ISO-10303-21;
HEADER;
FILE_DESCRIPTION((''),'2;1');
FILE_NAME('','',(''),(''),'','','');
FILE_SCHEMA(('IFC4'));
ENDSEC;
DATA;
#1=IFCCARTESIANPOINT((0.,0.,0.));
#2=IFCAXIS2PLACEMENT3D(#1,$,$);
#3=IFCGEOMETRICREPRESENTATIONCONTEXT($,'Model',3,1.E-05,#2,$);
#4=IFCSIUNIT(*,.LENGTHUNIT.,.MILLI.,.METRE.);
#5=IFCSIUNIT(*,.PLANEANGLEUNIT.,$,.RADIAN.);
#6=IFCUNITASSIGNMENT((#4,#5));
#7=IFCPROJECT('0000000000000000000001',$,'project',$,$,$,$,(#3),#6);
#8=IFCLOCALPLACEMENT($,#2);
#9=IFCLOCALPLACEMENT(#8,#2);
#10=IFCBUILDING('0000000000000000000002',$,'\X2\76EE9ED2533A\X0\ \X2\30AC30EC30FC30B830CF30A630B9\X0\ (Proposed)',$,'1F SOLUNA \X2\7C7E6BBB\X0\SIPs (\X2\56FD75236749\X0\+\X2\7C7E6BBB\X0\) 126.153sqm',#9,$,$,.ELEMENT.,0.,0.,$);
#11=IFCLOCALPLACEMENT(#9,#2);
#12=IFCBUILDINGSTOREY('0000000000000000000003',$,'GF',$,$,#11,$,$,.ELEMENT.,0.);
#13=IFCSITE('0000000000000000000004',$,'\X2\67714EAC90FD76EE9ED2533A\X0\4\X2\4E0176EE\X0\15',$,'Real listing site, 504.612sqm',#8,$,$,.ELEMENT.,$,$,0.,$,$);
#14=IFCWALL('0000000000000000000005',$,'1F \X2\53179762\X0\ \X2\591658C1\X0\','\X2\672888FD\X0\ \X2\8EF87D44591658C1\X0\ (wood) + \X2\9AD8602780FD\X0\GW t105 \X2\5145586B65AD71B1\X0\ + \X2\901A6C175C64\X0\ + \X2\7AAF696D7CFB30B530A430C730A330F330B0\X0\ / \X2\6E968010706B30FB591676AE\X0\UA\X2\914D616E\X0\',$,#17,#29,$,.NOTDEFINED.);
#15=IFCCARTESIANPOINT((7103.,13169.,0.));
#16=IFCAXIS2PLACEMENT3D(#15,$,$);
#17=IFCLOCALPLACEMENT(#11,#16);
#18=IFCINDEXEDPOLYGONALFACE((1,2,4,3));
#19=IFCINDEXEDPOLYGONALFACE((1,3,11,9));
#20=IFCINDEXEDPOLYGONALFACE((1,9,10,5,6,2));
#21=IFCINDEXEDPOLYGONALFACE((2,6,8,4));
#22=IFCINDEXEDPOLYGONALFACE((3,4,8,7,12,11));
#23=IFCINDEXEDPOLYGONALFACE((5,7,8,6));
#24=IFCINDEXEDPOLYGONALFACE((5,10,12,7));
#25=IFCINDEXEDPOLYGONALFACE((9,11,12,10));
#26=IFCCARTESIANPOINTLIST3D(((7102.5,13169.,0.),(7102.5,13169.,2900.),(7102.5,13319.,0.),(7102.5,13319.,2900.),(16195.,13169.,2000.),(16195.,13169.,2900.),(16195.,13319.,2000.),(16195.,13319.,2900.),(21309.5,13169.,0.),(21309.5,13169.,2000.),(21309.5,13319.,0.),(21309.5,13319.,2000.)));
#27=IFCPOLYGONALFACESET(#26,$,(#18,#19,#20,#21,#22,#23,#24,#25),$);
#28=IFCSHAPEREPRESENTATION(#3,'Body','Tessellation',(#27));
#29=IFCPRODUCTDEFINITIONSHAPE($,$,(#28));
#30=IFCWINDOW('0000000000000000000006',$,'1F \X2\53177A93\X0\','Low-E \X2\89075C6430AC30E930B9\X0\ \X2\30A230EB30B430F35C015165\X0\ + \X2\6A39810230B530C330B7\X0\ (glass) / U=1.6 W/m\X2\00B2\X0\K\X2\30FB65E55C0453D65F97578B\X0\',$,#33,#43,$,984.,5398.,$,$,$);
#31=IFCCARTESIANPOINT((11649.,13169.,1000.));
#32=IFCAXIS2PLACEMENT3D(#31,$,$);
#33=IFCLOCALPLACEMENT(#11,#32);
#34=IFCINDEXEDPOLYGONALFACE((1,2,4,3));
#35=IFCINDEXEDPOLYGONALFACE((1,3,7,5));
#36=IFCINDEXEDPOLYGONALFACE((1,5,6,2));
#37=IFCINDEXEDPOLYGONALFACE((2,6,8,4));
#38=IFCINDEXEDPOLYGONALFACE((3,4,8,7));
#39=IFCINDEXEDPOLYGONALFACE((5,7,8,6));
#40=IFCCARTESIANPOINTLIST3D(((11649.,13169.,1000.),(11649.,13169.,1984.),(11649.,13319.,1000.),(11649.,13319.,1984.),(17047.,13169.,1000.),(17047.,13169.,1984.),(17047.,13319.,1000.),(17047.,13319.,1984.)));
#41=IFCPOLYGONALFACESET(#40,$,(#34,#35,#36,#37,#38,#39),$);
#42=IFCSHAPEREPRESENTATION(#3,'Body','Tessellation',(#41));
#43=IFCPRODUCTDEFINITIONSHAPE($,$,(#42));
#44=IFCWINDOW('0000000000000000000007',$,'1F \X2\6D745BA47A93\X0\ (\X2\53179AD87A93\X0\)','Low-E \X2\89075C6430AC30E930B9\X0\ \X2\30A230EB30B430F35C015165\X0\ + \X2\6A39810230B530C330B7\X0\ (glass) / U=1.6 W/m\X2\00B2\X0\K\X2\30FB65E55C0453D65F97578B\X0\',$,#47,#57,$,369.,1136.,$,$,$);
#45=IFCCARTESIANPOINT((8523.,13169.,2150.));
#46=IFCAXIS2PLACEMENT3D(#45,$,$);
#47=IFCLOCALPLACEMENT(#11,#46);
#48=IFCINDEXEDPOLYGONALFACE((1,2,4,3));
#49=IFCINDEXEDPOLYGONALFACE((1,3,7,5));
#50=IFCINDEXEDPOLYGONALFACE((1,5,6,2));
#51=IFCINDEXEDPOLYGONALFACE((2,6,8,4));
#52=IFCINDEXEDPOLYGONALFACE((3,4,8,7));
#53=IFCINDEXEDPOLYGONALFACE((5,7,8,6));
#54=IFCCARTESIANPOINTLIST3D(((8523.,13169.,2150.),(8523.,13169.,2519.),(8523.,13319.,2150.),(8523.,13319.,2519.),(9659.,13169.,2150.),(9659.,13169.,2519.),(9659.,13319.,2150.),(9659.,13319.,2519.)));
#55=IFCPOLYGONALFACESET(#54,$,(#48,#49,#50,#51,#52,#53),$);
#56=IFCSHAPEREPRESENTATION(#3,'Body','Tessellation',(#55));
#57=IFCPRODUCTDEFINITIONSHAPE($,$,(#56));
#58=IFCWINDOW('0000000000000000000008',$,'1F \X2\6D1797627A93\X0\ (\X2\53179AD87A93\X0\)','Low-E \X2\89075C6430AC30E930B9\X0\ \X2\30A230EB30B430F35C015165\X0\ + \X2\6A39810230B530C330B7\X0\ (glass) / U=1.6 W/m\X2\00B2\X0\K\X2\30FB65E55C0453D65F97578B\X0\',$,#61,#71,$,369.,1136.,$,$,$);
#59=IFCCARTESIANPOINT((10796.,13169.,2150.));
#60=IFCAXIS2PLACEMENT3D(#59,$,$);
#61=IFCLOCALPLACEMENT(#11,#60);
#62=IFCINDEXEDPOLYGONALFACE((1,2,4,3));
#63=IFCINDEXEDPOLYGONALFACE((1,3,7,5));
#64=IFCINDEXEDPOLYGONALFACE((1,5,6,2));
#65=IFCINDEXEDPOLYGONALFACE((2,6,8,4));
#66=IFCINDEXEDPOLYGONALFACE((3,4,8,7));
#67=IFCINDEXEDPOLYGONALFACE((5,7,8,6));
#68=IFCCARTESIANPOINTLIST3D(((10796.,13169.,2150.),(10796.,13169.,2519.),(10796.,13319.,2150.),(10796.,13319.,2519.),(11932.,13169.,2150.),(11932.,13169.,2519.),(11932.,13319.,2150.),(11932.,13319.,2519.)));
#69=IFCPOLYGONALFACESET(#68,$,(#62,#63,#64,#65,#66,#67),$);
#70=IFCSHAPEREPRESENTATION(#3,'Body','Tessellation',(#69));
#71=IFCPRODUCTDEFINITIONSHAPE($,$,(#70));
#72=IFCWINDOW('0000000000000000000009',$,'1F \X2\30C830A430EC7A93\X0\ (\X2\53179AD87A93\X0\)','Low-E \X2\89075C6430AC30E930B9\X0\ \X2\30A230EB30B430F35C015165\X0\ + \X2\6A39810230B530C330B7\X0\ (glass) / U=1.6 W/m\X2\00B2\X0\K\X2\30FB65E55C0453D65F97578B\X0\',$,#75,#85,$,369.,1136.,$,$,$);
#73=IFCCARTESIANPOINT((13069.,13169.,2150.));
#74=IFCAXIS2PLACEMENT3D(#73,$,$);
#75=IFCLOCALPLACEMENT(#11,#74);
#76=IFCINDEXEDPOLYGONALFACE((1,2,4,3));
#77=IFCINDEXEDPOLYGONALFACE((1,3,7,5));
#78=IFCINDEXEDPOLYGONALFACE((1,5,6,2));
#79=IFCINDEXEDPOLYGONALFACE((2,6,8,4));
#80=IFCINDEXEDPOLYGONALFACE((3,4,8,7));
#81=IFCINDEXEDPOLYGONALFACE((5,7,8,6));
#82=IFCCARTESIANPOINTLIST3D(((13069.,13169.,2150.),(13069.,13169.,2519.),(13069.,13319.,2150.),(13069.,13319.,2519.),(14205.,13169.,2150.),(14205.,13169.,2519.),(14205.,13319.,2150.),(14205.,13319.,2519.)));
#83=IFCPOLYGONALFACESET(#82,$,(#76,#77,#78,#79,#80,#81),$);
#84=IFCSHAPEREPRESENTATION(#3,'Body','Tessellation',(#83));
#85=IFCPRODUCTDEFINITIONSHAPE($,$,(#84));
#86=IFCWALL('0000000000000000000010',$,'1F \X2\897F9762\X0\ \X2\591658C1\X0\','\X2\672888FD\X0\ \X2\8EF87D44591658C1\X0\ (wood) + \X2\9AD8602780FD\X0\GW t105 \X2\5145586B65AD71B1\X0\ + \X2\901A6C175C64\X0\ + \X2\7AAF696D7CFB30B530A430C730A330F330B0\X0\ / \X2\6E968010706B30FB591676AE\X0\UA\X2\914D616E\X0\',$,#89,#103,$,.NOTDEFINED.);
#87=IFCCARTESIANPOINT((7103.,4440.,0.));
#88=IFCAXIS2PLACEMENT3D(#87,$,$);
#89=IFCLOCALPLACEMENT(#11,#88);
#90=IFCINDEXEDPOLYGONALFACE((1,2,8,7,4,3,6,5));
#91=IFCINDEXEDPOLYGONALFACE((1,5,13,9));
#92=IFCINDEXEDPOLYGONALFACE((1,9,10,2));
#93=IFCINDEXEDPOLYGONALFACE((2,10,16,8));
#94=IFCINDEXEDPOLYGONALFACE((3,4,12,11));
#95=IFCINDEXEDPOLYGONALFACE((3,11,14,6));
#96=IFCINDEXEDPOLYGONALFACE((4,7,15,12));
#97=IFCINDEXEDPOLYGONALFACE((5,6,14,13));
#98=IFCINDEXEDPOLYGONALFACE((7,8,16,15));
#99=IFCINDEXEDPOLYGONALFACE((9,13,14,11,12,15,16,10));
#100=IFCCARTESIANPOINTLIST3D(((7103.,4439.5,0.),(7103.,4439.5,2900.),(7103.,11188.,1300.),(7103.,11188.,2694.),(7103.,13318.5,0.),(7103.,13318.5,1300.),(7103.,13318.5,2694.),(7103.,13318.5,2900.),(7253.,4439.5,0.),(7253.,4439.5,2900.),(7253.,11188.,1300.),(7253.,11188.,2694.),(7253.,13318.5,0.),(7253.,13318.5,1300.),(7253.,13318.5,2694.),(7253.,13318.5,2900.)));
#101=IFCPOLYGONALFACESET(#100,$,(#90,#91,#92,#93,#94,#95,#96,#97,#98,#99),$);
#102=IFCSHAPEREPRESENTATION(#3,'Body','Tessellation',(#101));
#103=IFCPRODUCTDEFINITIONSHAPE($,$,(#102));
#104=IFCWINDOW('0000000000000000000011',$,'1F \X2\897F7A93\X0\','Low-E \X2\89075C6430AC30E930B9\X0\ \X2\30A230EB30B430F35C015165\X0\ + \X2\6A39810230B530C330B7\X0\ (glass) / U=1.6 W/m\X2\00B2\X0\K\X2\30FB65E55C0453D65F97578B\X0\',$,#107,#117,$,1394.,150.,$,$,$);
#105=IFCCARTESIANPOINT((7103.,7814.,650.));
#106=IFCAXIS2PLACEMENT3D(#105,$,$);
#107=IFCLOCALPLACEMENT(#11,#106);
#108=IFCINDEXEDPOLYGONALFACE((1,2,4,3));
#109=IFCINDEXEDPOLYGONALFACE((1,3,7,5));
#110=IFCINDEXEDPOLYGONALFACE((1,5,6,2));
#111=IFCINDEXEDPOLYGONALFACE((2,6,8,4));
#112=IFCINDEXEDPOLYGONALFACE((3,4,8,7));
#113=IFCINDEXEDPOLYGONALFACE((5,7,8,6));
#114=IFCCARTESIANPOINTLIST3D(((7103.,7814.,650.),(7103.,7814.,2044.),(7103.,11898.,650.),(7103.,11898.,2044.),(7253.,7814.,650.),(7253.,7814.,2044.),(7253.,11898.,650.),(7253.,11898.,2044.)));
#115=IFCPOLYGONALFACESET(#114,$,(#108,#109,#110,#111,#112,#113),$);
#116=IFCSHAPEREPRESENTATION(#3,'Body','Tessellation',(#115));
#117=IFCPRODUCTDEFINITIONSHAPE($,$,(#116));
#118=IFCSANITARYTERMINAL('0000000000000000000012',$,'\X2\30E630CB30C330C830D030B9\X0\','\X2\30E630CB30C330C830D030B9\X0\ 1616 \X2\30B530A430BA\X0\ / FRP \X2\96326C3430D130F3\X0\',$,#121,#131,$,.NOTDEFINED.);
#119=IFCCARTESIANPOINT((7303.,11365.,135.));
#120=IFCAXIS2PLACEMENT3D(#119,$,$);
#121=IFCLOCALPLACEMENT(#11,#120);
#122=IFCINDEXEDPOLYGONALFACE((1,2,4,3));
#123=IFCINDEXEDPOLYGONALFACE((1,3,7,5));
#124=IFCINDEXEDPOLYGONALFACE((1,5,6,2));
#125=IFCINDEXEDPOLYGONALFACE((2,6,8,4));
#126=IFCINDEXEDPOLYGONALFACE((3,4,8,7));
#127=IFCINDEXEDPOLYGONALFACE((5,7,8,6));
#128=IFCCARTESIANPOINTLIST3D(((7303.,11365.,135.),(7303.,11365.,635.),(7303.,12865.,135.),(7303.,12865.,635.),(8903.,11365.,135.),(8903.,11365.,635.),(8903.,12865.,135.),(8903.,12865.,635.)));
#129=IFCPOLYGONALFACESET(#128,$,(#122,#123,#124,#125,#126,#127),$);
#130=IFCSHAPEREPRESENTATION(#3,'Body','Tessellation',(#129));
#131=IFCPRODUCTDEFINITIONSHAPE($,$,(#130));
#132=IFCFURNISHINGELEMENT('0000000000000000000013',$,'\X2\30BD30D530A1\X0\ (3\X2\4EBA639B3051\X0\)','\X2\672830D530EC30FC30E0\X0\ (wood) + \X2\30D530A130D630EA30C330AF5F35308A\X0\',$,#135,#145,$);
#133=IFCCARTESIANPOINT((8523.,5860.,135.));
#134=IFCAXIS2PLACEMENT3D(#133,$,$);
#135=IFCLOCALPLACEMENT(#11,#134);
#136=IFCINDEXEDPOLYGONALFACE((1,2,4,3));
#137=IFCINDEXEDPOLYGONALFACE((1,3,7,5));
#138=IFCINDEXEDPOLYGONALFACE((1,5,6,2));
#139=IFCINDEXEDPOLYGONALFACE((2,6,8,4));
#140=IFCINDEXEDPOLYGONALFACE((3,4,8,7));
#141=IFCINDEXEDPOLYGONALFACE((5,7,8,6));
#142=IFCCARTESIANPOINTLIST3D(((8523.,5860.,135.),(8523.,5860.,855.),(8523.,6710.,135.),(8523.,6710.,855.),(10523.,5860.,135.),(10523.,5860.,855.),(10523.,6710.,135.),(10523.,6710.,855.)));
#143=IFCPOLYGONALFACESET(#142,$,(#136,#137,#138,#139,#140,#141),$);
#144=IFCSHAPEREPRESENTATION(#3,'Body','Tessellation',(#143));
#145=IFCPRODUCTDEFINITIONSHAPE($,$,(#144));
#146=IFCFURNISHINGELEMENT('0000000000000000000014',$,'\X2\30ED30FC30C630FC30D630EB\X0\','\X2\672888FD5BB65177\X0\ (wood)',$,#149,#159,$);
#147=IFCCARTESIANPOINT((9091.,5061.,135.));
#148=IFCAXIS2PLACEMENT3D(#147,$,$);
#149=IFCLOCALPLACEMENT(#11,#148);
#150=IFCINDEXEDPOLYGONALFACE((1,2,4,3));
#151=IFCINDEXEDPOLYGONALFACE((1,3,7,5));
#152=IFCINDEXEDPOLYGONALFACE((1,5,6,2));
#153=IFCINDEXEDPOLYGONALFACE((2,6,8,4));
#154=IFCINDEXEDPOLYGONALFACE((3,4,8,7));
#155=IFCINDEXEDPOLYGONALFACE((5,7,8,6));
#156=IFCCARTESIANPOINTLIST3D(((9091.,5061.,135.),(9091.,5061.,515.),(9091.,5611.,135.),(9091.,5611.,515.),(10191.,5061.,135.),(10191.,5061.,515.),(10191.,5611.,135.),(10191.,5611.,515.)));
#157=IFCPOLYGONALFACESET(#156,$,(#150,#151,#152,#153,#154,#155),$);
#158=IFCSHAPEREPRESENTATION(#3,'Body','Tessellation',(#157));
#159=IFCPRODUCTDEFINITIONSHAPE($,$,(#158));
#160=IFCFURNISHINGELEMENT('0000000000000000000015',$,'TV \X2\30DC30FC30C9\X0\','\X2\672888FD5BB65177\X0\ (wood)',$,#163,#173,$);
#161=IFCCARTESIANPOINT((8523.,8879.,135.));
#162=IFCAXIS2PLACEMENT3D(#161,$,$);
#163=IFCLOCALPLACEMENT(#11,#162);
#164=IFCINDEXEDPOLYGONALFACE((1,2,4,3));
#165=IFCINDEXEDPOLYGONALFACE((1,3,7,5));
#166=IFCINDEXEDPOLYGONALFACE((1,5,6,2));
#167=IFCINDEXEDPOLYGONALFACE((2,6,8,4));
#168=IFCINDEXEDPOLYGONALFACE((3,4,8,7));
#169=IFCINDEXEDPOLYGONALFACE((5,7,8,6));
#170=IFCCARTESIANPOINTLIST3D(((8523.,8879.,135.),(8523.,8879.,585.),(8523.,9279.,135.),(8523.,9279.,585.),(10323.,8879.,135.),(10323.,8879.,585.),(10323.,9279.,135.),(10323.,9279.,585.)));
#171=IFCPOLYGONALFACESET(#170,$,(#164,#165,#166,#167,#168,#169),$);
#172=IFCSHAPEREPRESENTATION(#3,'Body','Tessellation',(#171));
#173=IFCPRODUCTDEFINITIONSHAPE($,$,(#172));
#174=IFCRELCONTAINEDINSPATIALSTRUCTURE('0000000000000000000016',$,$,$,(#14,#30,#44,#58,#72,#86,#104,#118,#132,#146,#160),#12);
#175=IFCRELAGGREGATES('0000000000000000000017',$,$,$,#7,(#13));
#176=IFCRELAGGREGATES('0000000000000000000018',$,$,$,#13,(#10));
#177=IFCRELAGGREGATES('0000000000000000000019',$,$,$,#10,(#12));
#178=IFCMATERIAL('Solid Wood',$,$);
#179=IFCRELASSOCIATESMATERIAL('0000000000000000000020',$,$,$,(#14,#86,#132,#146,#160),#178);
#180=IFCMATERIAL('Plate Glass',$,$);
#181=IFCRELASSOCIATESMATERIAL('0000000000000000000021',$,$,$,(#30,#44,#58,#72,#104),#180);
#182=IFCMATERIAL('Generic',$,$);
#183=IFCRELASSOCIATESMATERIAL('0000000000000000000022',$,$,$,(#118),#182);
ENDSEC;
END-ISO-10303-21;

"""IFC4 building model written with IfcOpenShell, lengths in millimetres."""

from ifc_helpers import new_model, si_unit, frame, frame_2d, origin, place, context, project, spatial, rectangle, extrude, material, element, fill, save


model = new_model("IFC4")

# Units and contexts
model_context = context("Model", 3, precision=1e-05, world=origin())
ifc_project = project(units=[si_unit("LENGTHUNIT", "METRE", prefix="MILLI"), si_unit("PLANEANGLEUNIT", "RADIAN")], contexts=[model_context])

# Site, building, storey
site_placement = place(None, origin())
site = spatial("IfcSite", under=ifc_project, at=site_placement, Name="東京都目黒区4丁目15", ObjectType="Real listing site, 504.612sqm", CompositionType="ELEMENT", RefElevation=0.0)
building_placement = place(site_placement, origin())
building = spatial("IfcBuilding", under=site, at=building_placement, Name="目黒区 ガレージハウス (Proposed)", ObjectType="1F SOLUNA 籾殻SIPs (国産杉+籾殻) 126.153sqm", CompositionType="ELEMENT", ElevationOfRefHeight=0.0, ElevationOfTerrain=0.0)
storey_placement = place(building_placement, origin())
storey = spatial("IfcBuildingStorey", under=building, at=storey_placement, Name="GF", CompositionType="ELEMENT", Elevation=0.0)

# Shared definitions
ifc_material_1 = material(Name="Solid Wood")

# Shared definitions
ifc_material_2 = material(Name="Plate Glass")

# Wall, openings, windows
wall_1_placement = place(storey_placement, frame((7103.0, 13169.0, 0.0)))
wall_1 = element("IfcWall", 1, at=wall_1_placement, inside=storey, material=ifc_material_1, Name="1F 北面 外壁", Description="木製 軸組外壁 (wood) + 高性能GW t105 充填断熱 + 通気層 + 窯業系サイディング / 準耐火・外皮UA配慮", PredefinedType="NOTDEFINED", context=model_context, shape_type="SweptSolid", body=[
    extrude(rectangle(XDim=14207.0, YDim=150.0, at=frame_2d((7103.0, 75.0))), frame((7103.0, 13169.0, 0.0)), (0.0, 0.0, 1.0), 2900.0),
])
opening_1_placement = place(storey_placement, frame((11649.0, 13169.0, 1000.0)))
opening_1 = element("IfcOpeningElement", 2, at=opening_1_placement, cuts=wall_1, PredefinedType="NOTDEFINED", context=model_context, shape_type="SweptSolid", body=[
    extrude(rectangle(XDim=5398.0, YDim=150.0, at=frame_2d((2699.0, 75.0))), frame((11649.0, 13169.0, 1000.0)), (0.0, 0.0, 1.0), 984.0),
])
opening_2_placement = place(storey_placement, frame((8523.0, 13169.0, 2150.0)))
opening_2 = element("IfcOpeningElement", 3, at=opening_2_placement, cuts=wall_1, PredefinedType="NOTDEFINED", context=model_context, shape_type="SweptSolid", body=[
    extrude(rectangle(XDim=1136.0, YDim=150.0, at=frame_2d((568.0, 75.0))), frame((8523.0, 13169.0, 2150.0)), (0.0, 0.0, 1.0), 369.0),
])
opening_3_placement = place(storey_placement, frame((10796.0, 13169.0, 2150.0)))
opening_3 = element("IfcOpeningElement", 4, at=opening_3_placement, cuts=wall_1, PredefinedType="NOTDEFINED", context=model_context, shape_type="SweptSolid", body=[
    extrude(rectangle(XDim=1136.0, YDim=150.0, at=frame_2d((568.0, 75.0))), frame((10796.0, 13169.0, 2150.0)), (0.0, 0.0, 1.0), 369.0),
])
opening_4_placement = place(storey_placement, frame((13069.0, 13169.0, 2150.0)))
opening_4 = element("IfcOpeningElement", 5, at=opening_4_placement, cuts=wall_1, PredefinedType="NOTDEFINED", context=model_context, shape_type="SweptSolid", body=[
    extrude(rectangle(XDim=1136.0, YDim=150.0, at=frame_2d((568.0, 75.0))), frame((13069.0, 13169.0, 2150.0)), (0.0, 0.0, 1.0), 369.0),
])
window_1_placement = place(storey_placement, frame((11649.0, 13169.0, 1000.0)))
window_1 = element("IfcWindow", 6, at=window_1_placement, inside=storey, material=ifc_material_2, Name="1F 北窓", Description="Low-E 複層ガラス アルゴン封入 + 樹脂サッシ (glass) / U=1.6 W/m²K・日射取得型", OverallHeight=984.0, OverallWidth=5398.0, context=model_context, shape_type="SweptSolid", body=[
    extrude(rectangle(XDim=5398.0, YDim=150.0, at=frame_2d((2699.0, 75.0))), frame((11649.0, 13169.0, 1000.0)), (0.0, 0.0, 1.0), 984.0),
])
fill(opening_1, window_1)
window_2_placement = place(storey_placement, frame((8523.0, 13169.0, 2150.0)))
window_2 = element("IfcWindow", 7, at=window_2_placement, inside=storey, material=ifc_material_2, Name="1F 浴室窓 (北高窓)", Description="Low-E 複層ガラス アルゴン封入 + 樹脂サッシ (glass) / U=1.6 W/m²K・日射取得型", OverallHeight=369.0, OverallWidth=1136.0, context=model_context, shape_type="SweptSolid", body=[
    extrude(rectangle(XDim=1136.0, YDim=150.0, at=frame_2d((568.0, 75.0))), frame((8523.0, 13169.0, 2150.0)), (0.0, 0.0, 1.0), 369.0),
])
fill(opening_2, window_2)
window_3_placement = place(storey_placement, frame((10796.0, 13169.0, 2150.0)))
window_3 = element("IfcWindow", 8, at=window_3_placement, inside=storey, material=ifc_material_2, Name="1F 洗面窓 (北高窓)", Description="Low-E 複層ガラス アルゴン封入 + 樹脂サッシ (glass) / U=1.6 W/m²K・日射取得型", OverallHeight=369.0, OverallWidth=1136.0, context=model_context, shape_type="SweptSolid", body=[
    extrude(rectangle(XDim=1136.0, YDim=150.0, at=frame_2d((568.0, 75.0))), frame((10796.0, 13169.0, 2150.0)), (0.0, 0.0, 1.0), 369.0),
])
fill(opening_3, window_3)
window_4_placement = place(storey_placement, frame((13069.0, 13169.0, 2150.0)))
window_4 = element("IfcWindow", 9, at=window_4_placement, inside=storey, material=ifc_material_2, Name="1F トイレ窓 (北高窓)", Description="Low-E 複層ガラス アルゴン封入 + 樹脂サッシ (glass) / U=1.6 W/m²K・日射取得型", OverallHeight=369.0, OverallWidth=1136.0, context=model_context, shape_type="SweptSolid", body=[
    extrude(rectangle(XDim=1136.0, YDim=150.0, at=frame_2d((568.0, 75.0))), frame((13069.0, 13169.0, 2150.0)), (0.0, 0.0, 1.0), 369.0),
])
fill(opening_4, window_4)

# Wall, opening, window
wall_2_placement = place(storey_placement, frame((7103.0, 4440.0, 0.0)))
wall_2 = element("IfcWall", 10, at=wall_2_placement, inside=storey, material=ifc_material_1, Name="1F 西面 外壁", Description="木製 軸組外壁 (wood) + 高性能GW t105 充填断熱 + 通気層 + 窯業系サイディング / 準耐火・外皮UA配慮", PredefinedType="NOTDEFINED", context=model_context, shape_type="SweptSolid", body=[
    extrude(rectangle(XDim=150.0, YDim=8879.0, at=frame_2d((75.0, 4439.0))), frame((7103.0, 4440.0, 0.0)), (0.0, 0.0, 1.0), 2900.0),
])
opening_5_placement = place(storey_placement, frame((7103.0, 7814.0, 650.0)))
opening_5 = element("IfcOpeningElement", 11, at=opening_5_placement, cuts=wall_2, PredefinedType="NOTDEFINED", context=model_context, shape_type="SweptSolid", body=[
    extrude(rectangle(XDim=150.0, YDim=4084.0, at=frame_2d((75.0, 2042.0))), frame((7103.0, 7814.0, 650.0)), (0.0, 0.0, 1.0), 1394.0),
])
window_5_placement = place(storey_placement, frame((7103.0, 7814.0, 650.0)))
window_5 = element("IfcWindow", 12, at=window_5_placement, inside=storey, material=ifc_material_2, Name="1F 西窓", Description="Low-E 複層ガラス アルゴン封入 + 樹脂サッシ (glass) / U=1.6 W/m²K・日射取得型", OverallHeight=1394.0, OverallWidth=150.0, context=model_context, shape_type="SweptSolid", body=[
    extrude(rectangle(XDim=150.0, YDim=4084.0, at=frame_2d((75.0, 2042.0))), frame((7103.0, 7814.0, 650.0)), (0.0, 0.0, 1.0), 1394.0),
])
fill(opening_5, window_5)

# Shared definitions
ifc_material_3 = material(Name="Generic")

# Sanitary terminal
sanitary_terminal_placement = place(storey_placement, frame((7303.0, 11365.0, 135.0)))
element("IfcSanitaryTerminal", 13, at=sanitary_terminal_placement, inside=storey, material=ifc_material_3, Name="ユニットバス", Description="ユニットバス 1616 サイズ / FRP 防水パン", PredefinedType="NOTDEFINED", context=model_context, shape_type="SweptSolid", body=[
    extrude(rectangle(XDim=1600.0, YDim=1500.0, at=frame_2d((800.0, 750.0))), frame((7303.0, 11365.0, 135.0)), (0.0, 0.0, 1.0), 500.0),
])

# Furnishing elements
furnishing_1_placement = place(storey_placement, frame((8523.0, 5860.0, 135.0)))
element("IfcFurnishingElement", 14, at=furnishing_1_placement, inside=storey, material=ifc_material_1, Name="ソファ (3人掛け)", Description="木フレーム (wood) + ファブリック張り", context=model_context, shape_type="SweptSolid", body=[
    extrude(rectangle(XDim=2000.0, YDim=850.0, at=frame_2d((1000.0, 425.0))), frame((8523.0, 5860.0, 135.0)), (0.0, 0.0, 1.0), 720.0),
])
furnishing_2_placement = place(storey_placement, frame((9091.0, 5061.0, 135.0)))
element("IfcFurnishingElement", 15, at=furnishing_2_placement, inside=storey, material=ifc_material_1, Name="ローテーブル", Description="木製家具 (wood)", context=model_context, shape_type="SweptSolid", body=[
    extrude(rectangle(XDim=1100.0, YDim=550.0, at=frame_2d((550.0, 275.0))), frame((9091.0, 5061.0, 135.0)), (0.0, 0.0, 1.0), 380.0),
])
furnishing_3_placement = place(storey_placement, frame((8523.0, 8879.0, 135.0)))
element("IfcFurnishingElement", 16, at=furnishing_3_placement, inside=storey, material=ifc_material_1, Name="TV ボード", Description="木製家具 (wood)", context=model_context, shape_type="SweptSolid", body=[
    extrude(rectangle(XDim=1800.0, YDim=400.0, at=frame_2d((900.0, 200.0))), frame((8523.0, 8879.0, 135.0)), (0.0, 0.0, 1.0), 450.0),
])

save(model, "model.ifc")
